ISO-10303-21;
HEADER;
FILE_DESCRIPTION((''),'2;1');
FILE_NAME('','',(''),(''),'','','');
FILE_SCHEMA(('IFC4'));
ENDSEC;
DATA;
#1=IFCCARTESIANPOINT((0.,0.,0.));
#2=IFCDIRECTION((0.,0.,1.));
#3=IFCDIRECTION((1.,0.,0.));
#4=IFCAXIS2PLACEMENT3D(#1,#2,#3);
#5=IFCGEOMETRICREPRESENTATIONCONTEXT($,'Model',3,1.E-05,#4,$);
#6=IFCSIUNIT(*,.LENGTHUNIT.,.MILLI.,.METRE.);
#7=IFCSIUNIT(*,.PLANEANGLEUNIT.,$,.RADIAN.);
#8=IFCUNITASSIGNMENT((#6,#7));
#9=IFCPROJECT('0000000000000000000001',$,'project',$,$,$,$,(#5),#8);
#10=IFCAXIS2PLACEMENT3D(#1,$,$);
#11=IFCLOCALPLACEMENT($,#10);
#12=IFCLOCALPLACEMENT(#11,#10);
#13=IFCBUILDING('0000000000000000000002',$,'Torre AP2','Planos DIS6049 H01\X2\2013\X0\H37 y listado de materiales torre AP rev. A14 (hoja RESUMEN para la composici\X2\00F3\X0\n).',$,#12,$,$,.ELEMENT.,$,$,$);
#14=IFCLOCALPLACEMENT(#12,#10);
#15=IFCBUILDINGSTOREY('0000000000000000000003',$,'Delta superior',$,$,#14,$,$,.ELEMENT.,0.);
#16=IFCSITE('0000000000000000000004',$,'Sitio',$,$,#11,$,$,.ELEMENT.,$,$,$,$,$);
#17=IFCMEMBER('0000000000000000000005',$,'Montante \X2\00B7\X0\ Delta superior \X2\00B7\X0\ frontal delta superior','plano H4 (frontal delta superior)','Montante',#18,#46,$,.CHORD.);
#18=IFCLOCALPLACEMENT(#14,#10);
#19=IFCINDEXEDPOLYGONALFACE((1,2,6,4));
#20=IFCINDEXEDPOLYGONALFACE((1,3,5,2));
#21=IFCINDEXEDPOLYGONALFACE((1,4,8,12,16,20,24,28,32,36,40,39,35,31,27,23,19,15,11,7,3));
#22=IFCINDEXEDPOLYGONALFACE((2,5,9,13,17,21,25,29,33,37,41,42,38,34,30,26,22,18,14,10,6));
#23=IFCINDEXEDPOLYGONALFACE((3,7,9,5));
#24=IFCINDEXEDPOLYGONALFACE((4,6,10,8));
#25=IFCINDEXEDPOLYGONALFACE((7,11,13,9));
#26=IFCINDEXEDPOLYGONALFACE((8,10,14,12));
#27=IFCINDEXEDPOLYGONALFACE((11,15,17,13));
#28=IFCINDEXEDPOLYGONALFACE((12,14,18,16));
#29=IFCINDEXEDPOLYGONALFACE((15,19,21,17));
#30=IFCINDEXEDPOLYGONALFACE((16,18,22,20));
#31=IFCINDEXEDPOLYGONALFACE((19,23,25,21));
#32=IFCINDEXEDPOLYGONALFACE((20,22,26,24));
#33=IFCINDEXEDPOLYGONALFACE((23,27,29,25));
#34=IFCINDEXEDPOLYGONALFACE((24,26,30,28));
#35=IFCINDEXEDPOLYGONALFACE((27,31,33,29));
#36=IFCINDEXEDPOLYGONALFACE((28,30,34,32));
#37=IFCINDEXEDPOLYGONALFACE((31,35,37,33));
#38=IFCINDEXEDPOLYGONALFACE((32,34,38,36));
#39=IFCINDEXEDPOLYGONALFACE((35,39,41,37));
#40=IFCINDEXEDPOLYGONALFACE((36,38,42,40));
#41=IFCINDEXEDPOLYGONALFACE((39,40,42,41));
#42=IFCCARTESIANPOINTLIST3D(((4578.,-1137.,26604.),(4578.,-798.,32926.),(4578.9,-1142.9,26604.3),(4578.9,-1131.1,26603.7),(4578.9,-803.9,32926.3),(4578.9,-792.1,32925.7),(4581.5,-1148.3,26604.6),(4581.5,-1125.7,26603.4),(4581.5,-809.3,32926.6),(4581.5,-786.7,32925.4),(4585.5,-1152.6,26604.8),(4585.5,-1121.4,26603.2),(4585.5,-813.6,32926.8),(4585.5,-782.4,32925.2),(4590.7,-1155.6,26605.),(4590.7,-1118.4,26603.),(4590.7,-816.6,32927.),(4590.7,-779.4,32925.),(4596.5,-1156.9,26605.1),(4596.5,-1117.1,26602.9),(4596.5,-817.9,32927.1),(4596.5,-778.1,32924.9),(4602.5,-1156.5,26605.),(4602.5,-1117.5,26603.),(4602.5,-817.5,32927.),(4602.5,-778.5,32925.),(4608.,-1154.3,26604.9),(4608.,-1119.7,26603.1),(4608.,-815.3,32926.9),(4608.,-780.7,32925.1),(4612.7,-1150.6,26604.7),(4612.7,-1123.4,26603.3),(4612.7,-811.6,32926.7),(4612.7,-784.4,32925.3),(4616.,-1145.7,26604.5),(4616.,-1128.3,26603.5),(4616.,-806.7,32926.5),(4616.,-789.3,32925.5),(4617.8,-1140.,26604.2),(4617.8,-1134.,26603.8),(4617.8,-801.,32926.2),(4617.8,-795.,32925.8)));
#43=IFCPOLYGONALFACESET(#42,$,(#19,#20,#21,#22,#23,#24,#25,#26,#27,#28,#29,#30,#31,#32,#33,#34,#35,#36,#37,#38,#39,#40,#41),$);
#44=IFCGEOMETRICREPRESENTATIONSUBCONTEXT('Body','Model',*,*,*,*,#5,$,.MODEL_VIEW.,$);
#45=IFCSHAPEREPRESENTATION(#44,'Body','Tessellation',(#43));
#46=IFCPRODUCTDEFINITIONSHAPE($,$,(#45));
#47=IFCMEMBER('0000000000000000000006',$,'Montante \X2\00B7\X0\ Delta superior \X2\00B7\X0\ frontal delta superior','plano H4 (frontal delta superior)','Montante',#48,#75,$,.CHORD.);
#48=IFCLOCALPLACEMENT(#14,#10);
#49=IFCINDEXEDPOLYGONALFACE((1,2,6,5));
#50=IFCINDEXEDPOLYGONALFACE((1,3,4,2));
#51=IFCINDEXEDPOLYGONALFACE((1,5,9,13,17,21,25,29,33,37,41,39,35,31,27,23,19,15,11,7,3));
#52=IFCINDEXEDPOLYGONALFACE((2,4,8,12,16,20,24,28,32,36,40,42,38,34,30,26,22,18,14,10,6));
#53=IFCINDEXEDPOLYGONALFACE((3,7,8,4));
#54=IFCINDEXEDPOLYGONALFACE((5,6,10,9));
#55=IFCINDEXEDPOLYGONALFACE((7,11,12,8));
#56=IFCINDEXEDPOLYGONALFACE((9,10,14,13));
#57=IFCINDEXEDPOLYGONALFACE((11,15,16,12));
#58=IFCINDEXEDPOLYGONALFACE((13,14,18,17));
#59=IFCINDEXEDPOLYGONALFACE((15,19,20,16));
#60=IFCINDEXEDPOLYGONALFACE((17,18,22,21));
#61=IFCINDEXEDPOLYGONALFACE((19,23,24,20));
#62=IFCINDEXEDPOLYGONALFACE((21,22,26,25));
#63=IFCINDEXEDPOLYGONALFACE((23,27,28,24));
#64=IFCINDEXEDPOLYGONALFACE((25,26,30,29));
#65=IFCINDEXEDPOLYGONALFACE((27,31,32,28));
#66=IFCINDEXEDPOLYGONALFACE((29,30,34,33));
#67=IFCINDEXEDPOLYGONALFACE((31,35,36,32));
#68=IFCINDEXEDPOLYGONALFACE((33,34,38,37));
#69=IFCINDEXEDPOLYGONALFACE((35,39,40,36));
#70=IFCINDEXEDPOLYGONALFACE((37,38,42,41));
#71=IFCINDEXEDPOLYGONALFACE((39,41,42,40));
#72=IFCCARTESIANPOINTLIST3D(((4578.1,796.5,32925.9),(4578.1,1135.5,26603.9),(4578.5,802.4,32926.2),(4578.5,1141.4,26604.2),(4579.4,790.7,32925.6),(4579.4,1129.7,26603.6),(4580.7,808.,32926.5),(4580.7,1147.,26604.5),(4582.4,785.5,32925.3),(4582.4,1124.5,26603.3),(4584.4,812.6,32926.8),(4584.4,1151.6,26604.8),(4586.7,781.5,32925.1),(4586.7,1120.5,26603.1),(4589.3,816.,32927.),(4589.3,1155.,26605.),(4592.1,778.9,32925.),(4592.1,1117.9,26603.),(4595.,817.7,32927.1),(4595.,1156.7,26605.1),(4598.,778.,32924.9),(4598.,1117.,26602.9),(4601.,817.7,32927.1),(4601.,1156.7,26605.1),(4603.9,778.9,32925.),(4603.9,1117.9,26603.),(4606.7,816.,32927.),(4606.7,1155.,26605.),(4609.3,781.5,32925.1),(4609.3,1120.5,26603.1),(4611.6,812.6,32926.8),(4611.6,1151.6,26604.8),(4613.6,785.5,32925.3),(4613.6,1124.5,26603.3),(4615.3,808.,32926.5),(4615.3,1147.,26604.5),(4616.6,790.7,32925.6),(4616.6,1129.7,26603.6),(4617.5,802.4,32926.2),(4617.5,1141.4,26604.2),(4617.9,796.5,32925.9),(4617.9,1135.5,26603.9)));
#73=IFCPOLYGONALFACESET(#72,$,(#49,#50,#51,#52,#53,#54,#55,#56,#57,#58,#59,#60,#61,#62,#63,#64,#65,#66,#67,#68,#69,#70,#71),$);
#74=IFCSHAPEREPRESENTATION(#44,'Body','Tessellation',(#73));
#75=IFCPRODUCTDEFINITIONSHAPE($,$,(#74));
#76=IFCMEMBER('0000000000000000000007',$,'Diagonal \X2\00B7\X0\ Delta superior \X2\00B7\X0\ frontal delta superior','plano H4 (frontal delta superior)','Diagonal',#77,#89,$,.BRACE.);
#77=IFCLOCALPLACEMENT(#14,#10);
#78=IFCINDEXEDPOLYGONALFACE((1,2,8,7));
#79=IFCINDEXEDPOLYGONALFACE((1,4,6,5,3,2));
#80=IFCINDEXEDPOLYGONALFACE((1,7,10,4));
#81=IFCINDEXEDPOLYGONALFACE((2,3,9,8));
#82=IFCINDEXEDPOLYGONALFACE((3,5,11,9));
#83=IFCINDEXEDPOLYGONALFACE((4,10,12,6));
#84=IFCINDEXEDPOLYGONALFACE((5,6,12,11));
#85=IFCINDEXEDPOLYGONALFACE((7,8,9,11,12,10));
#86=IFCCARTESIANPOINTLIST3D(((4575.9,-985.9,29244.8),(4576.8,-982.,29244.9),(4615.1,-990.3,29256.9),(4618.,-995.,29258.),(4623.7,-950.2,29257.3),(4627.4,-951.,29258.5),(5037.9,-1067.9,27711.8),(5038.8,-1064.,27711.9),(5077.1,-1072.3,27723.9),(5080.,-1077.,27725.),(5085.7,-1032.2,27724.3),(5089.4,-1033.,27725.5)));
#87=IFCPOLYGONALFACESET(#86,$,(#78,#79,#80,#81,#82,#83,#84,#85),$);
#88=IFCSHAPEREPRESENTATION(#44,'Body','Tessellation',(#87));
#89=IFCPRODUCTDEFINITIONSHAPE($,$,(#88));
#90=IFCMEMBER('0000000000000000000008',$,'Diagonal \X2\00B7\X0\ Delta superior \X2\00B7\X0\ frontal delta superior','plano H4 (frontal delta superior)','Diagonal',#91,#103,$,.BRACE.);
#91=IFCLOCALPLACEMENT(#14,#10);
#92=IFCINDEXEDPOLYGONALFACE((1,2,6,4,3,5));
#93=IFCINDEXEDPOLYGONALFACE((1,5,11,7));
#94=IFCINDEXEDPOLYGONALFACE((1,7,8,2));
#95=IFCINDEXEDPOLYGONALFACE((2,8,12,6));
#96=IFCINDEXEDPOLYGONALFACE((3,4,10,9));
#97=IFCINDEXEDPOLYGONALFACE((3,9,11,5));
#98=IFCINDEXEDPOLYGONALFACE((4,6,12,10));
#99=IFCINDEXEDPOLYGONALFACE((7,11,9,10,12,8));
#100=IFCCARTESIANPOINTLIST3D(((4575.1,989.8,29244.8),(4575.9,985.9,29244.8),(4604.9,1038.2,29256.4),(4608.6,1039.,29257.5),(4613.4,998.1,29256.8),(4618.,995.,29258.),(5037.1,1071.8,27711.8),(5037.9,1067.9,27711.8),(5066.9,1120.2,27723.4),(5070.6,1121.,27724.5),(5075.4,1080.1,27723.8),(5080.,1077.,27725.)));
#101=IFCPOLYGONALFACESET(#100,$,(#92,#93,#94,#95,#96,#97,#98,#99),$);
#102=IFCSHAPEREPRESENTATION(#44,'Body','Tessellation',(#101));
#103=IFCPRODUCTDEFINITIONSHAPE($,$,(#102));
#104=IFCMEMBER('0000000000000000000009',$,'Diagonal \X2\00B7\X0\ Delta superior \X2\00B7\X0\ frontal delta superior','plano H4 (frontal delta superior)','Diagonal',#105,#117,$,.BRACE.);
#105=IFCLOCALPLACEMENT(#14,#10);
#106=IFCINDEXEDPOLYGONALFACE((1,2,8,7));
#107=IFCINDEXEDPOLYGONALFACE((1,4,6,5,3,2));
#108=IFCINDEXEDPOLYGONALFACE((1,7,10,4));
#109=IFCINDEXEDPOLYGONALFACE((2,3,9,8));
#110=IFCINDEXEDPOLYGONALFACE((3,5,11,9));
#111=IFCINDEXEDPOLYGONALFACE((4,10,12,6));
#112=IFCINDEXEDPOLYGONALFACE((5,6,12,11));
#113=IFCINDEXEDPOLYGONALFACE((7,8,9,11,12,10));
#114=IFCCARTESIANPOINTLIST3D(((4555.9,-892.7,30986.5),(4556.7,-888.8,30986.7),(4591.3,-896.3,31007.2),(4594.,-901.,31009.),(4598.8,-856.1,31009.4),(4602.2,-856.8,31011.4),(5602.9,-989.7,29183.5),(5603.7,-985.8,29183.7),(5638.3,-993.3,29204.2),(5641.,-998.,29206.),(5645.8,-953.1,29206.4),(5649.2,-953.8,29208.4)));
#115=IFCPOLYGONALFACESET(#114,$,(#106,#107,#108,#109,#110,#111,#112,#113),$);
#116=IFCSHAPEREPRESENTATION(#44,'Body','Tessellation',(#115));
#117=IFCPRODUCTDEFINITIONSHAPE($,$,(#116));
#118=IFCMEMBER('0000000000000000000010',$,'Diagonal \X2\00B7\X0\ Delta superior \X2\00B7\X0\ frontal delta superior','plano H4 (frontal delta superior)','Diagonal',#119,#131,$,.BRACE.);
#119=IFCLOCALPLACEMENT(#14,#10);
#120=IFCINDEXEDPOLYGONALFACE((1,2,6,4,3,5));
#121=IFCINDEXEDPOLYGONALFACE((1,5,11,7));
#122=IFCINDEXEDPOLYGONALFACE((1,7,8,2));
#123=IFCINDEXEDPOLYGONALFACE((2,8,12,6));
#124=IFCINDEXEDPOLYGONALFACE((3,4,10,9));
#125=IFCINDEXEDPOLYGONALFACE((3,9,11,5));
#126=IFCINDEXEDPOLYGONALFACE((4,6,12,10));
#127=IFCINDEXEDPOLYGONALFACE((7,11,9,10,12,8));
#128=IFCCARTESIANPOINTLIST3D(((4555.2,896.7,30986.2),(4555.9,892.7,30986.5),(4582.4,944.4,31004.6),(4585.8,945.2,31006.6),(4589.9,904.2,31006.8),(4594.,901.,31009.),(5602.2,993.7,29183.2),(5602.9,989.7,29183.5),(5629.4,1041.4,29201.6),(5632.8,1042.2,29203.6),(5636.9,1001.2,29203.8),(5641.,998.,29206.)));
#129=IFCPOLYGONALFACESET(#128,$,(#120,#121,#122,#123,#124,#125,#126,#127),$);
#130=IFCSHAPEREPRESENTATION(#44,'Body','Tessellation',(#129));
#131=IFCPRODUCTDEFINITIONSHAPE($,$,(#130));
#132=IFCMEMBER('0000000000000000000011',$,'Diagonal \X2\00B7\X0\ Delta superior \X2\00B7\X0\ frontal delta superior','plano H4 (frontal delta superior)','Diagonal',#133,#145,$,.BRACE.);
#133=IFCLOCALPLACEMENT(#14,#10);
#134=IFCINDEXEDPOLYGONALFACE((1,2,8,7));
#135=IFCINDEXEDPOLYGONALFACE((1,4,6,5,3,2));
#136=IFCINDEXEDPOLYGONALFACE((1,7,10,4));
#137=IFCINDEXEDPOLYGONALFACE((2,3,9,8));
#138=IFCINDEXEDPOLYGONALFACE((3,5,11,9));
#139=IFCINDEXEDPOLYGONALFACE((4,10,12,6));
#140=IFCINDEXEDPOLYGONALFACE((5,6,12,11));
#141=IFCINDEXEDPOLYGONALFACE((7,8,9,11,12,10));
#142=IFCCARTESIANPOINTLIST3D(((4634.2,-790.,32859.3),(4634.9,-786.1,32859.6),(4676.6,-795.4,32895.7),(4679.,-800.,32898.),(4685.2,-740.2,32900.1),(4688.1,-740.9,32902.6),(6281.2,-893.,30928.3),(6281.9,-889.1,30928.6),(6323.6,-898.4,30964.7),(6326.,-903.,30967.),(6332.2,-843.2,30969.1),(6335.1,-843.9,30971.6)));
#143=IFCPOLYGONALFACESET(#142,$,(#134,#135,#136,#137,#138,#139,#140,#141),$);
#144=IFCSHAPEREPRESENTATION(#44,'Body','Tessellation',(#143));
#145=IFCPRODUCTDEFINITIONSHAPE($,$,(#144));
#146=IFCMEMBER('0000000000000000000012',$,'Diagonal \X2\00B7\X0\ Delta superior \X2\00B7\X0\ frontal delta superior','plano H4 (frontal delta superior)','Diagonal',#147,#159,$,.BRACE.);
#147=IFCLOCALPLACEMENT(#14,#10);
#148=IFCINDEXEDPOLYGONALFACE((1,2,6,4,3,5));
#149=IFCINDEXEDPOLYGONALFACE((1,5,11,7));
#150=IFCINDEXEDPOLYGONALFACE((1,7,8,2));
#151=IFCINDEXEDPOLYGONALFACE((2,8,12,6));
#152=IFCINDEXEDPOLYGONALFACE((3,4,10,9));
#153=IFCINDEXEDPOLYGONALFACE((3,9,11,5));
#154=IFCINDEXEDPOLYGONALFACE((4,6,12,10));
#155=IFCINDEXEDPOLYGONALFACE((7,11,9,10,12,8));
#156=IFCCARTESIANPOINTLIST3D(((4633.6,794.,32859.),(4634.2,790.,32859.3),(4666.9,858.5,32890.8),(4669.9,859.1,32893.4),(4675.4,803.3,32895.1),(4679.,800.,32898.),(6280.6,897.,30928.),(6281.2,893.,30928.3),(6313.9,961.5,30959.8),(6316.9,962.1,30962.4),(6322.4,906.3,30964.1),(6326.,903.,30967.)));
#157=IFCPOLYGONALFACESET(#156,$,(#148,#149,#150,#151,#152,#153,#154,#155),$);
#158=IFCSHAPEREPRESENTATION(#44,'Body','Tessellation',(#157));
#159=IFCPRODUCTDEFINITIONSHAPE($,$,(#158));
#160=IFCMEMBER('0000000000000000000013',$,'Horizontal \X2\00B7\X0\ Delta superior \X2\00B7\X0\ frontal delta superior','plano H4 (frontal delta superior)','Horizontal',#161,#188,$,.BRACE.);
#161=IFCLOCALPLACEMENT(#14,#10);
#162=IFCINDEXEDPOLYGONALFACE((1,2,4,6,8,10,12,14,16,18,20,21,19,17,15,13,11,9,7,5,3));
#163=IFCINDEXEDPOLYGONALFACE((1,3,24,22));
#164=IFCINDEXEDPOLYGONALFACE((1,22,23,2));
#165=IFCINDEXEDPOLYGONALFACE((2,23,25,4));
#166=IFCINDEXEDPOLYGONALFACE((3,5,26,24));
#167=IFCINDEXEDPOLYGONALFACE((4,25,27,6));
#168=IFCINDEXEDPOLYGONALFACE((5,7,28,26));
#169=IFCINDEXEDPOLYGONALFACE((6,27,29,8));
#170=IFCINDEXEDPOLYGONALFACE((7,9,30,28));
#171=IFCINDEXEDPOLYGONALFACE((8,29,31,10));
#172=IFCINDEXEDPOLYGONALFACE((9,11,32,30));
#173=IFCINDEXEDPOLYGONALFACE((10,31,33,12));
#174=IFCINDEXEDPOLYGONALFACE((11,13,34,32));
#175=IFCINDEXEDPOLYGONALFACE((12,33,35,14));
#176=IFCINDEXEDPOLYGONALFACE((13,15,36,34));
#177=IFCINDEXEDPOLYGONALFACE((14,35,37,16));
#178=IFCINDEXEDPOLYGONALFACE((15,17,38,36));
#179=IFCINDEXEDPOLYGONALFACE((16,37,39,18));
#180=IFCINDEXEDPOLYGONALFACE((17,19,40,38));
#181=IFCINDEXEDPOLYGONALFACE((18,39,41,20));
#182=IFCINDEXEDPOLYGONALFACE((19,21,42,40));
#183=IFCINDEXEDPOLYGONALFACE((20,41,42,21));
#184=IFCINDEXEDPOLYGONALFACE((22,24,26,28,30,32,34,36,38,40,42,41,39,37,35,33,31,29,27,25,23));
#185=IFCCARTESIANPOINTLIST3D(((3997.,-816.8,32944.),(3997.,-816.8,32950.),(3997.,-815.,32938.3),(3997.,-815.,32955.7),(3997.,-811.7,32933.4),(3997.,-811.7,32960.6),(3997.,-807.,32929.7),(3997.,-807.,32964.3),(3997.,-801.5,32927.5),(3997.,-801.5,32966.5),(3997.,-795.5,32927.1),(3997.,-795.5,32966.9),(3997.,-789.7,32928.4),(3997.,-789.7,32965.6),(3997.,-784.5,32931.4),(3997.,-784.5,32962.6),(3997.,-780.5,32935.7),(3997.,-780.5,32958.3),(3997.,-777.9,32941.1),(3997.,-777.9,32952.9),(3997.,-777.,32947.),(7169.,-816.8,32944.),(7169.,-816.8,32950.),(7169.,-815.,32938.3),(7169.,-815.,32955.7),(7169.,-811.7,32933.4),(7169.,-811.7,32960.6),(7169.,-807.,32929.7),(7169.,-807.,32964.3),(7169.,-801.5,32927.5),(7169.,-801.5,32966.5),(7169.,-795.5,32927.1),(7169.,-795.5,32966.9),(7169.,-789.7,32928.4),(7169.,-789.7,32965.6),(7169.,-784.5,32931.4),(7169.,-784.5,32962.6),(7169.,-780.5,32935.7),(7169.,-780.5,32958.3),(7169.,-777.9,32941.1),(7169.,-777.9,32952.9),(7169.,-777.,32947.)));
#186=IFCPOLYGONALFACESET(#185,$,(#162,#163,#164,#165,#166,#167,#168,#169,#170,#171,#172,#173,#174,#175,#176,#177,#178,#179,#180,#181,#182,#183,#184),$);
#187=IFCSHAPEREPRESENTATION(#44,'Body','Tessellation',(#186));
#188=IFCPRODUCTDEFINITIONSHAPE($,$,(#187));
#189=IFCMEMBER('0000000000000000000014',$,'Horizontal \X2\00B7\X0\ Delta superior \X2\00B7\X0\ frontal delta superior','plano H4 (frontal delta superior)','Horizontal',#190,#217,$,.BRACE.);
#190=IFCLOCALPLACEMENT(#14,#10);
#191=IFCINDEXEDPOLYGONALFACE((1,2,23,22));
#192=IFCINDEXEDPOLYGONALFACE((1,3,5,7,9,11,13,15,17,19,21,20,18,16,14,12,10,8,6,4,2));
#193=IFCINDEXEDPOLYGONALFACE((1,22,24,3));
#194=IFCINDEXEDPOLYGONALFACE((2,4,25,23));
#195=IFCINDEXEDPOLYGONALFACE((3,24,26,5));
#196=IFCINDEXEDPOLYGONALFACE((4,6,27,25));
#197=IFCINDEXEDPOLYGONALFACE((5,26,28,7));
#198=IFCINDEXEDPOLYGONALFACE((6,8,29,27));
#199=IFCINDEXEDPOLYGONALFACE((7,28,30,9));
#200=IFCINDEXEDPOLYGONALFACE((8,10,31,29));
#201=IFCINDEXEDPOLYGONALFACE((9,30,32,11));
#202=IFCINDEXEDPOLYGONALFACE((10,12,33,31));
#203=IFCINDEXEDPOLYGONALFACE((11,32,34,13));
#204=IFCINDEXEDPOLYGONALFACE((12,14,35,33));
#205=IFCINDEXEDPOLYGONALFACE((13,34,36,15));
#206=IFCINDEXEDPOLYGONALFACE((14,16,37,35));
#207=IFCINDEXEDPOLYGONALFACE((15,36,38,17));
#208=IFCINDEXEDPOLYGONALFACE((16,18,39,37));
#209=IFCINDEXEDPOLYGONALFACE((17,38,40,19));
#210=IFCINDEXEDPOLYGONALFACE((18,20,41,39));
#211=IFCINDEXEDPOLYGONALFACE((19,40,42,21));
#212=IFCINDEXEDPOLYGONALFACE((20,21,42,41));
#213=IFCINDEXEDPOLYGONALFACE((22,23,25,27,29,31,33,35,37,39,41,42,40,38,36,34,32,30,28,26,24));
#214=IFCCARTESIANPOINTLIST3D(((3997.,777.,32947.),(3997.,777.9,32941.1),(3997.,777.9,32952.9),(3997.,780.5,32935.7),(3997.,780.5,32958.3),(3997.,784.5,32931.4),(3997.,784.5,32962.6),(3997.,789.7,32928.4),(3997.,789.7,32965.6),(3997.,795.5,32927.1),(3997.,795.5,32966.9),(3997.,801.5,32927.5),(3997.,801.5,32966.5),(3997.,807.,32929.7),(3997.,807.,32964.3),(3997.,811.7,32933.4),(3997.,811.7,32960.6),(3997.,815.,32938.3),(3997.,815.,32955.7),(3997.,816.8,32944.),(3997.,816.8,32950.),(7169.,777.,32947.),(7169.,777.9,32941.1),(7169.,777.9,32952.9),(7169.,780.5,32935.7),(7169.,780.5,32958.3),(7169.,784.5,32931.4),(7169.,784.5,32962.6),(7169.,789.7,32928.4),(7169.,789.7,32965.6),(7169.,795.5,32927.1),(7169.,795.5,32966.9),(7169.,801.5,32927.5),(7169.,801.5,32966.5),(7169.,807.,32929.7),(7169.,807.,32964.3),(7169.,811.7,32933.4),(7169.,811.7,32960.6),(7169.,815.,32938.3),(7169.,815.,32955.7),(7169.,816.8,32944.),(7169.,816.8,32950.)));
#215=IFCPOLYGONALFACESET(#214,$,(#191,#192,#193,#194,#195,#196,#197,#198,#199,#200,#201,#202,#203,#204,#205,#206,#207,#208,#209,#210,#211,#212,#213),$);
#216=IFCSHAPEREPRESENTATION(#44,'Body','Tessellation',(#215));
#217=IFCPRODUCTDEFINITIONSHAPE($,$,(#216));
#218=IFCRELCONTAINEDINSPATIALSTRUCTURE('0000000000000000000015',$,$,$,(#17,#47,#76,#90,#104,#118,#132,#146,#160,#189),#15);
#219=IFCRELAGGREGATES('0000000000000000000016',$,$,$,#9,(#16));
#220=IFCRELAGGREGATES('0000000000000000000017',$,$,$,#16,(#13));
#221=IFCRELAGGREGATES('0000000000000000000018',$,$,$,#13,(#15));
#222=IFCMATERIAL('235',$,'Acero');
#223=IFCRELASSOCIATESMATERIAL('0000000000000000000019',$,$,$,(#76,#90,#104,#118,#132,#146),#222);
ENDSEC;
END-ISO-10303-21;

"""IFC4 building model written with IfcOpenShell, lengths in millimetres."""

from ifc_helpers import new_model, si_unit, frame, frame_2d, origin, origin_with_axes, place, context, subcontext, project, spatial, circle, l_section, extrude, material, element, save


model = new_model("IFC4")

# Units and contexts
model_context = context("Model", 3, precision=1e-05, world=origin_with_axes())
body_context = subcontext(model_context, "Body", "Model", "MODEL_VIEW")
ifc_project = project(units=[si_unit("LENGTHUNIT", "METRE", prefix="MILLI"), si_unit("PLANEANGLEUNIT", "RADIAN")], contexts=[model_context])

# Site, building, storey
site_placement = place(None, origin())
site = spatial("IfcSite", under=ifc_project, at=site_placement, Name="Sitio", CompositionType="ELEMENT")
building_placement = place(site_placement, origin())
building = spatial("IfcBuilding", under=site, at=building_placement, Name="Torre AP2", Description="Planos DIS6049 H01–H37 y listado de materiales torre AP rev. A14 (hoja RESUMEN para la composición).", CompositionType="ELEMENT")
storey_placement = place(building_placement, origin())
storey = spatial("IfcBuildingStorey", under=building, at=storey_placement, Name="Delta superior", CompositionType="ELEMENT", Elevation=0.0)

# Members
for number, where, z_axis, x_axis, name in (
    (1, (4598.0, -798.0, 32926.0), (0.0, -0.053545, -0.998565), (-1.0, 0.0, 0.0), "Montante · Delta superior · frontal delta superior"),
    (2, (4598.0, 798.0, 32926.0), (0.0, 0.053545, -0.998565), (0.0, -0.998565, -0.053545), "Montante · Delta superior · frontal delta superior"),
):
    element("IfcMember", number, at=place(storey_placement, frame(where, z_axis=z_axis, x_axis=x_axis)), inside=storey, Name=name, Description="plano H4 (frontal delta superior)", ObjectType="Montante", PredefinedType="CHORD", context=body_context, shape_type="SweptSolid", body=[
        extrude(circle(Radius=20.0), None, (0.0, 0.0, 1.0), 6331.1),
    ])
ifc_material_1 = material(Name="235", Category="Acero")
for number, where, z_axis, x_axis, name in (
    (3, (4618.0, -995.0, 29258.0), (0.288173, -0.051148, -0.956211), (-0.934509, 0.202848, -0.292483), "Diagonal · Delta superior · frontal delta superior"),
    (4, (4618.0, 995.0, 29258.0), (0.288173, 0.051148, -0.956211), (-0.934509, -0.202848, -0.292483), "Diagonal · Delta superior · frontal delta superior"),
):
    element("IfcMember", number, at=place(storey_placement, frame(where, z_axis=z_axis, x_axis=x_axis)), inside=storey, material=ifc_material_1, Name=name, Description="plano H4 (frontal delta superior)", ObjectType="Diagonal", PredefinedType="BRACE", context=body_context, shape_type="SweptSolid", body=[
        extrude(l_section(Depth=45.0, Width=45.0, Thickness=4.0, at=frame_2d((22.5, 22.5))), None, (0.0, 0.0, 1.0), 1603.2),
    ])
for number, where, z_axis, x_axis, name in (
    (5, (4594.0, -901.0, 31009.0), (0.501628, -0.046474, -0.863834), (-0.845685, 0.183933, -0.500984), "Diagonal · Delta superior · frontal delta superior"),
    (6, (4594.0, 901.0, 31009.0), (0.501628, 0.046474, -0.863834), (-0.845685, -0.183933, -0.500984), "Diagonal · Delta superior · frontal delta superior"),
):
    element("IfcMember", number, at=place(storey_placement, frame(where, z_axis=z_axis, x_axis=x_axis)), inside=storey, material=ifc_material_1, Name=name, Description="plano H4 (frontal delta superior)", ObjectType="Diagonal", PredefinedType="BRACE", context=body_context, shape_type="SweptSolid", body=[
        extrude(l_section(Depth=45.0, Width=45.0, Thickness=4.0, at=frame_2d((22.5, 22.5))), None, (0.0, 0.0, 1.0), 2087.2),
    ])
for number, where, z_axis, x_axis, name in (
    (7, (4679.0, -800.0, 32898.0), (0.648406, -0.04055, -0.760214), (-0.745871, 0.166153, -0.645035), "Diagonal · Delta superior · frontal delta superior"),
    (8, (4679.0, 800.0, 32898.0), (0.648406, 0.04055, -0.760214), (-0.745871, -0.166153, -0.645035), "Diagonal · Delta superior · frontal delta superior"),
):
    element("IfcMember", number, at=place(storey_placement, frame(where, z_axis=z_axis, x_axis=x_axis)), inside=storey, material=ifc_material_1, Name=name, Description="plano H4 (frontal delta superior)", ObjectType="Diagonal", PredefinedType="BRACE", context=body_context, shape_type="SweptSolid", body=[
        extrude(l_section(Depth=60.0, Width=60.0, Thickness=4.0, at=frame_2d((30.0, 30.0))), None, (0.0, 0.0, 1.0), 2540.1),
    ])
for number, where, z_axis, x_axis, name in (
    (9, (3997.0, -797.0, 32947.0), (1.0, 0.0, 0.0), (0.0, 1.0, 0.0), "Horizontal · Delta superior · frontal delta superior"),
    (10, (3997.0, 797.0, 32947.0), (1.0, 0.0, 0.0), (0.0, -1.0, 0.0), "Horizontal · Delta superior · frontal delta superior"),
):
    element("IfcMember", number, at=place(storey_placement, frame(where, z_axis=z_axis, x_axis=x_axis)), inside=storey, Name=name, Description="plano H4 (frontal delta superior)", ObjectType="Horizontal", PredefinedType="BRACE", context=body_context, shape_type="SweptSolid", body=[
        extrude(circle(Radius=20.0), None, (0.0, 0.0, 1.0), 3172.0),
    ])

save(model, "model.ifc")
